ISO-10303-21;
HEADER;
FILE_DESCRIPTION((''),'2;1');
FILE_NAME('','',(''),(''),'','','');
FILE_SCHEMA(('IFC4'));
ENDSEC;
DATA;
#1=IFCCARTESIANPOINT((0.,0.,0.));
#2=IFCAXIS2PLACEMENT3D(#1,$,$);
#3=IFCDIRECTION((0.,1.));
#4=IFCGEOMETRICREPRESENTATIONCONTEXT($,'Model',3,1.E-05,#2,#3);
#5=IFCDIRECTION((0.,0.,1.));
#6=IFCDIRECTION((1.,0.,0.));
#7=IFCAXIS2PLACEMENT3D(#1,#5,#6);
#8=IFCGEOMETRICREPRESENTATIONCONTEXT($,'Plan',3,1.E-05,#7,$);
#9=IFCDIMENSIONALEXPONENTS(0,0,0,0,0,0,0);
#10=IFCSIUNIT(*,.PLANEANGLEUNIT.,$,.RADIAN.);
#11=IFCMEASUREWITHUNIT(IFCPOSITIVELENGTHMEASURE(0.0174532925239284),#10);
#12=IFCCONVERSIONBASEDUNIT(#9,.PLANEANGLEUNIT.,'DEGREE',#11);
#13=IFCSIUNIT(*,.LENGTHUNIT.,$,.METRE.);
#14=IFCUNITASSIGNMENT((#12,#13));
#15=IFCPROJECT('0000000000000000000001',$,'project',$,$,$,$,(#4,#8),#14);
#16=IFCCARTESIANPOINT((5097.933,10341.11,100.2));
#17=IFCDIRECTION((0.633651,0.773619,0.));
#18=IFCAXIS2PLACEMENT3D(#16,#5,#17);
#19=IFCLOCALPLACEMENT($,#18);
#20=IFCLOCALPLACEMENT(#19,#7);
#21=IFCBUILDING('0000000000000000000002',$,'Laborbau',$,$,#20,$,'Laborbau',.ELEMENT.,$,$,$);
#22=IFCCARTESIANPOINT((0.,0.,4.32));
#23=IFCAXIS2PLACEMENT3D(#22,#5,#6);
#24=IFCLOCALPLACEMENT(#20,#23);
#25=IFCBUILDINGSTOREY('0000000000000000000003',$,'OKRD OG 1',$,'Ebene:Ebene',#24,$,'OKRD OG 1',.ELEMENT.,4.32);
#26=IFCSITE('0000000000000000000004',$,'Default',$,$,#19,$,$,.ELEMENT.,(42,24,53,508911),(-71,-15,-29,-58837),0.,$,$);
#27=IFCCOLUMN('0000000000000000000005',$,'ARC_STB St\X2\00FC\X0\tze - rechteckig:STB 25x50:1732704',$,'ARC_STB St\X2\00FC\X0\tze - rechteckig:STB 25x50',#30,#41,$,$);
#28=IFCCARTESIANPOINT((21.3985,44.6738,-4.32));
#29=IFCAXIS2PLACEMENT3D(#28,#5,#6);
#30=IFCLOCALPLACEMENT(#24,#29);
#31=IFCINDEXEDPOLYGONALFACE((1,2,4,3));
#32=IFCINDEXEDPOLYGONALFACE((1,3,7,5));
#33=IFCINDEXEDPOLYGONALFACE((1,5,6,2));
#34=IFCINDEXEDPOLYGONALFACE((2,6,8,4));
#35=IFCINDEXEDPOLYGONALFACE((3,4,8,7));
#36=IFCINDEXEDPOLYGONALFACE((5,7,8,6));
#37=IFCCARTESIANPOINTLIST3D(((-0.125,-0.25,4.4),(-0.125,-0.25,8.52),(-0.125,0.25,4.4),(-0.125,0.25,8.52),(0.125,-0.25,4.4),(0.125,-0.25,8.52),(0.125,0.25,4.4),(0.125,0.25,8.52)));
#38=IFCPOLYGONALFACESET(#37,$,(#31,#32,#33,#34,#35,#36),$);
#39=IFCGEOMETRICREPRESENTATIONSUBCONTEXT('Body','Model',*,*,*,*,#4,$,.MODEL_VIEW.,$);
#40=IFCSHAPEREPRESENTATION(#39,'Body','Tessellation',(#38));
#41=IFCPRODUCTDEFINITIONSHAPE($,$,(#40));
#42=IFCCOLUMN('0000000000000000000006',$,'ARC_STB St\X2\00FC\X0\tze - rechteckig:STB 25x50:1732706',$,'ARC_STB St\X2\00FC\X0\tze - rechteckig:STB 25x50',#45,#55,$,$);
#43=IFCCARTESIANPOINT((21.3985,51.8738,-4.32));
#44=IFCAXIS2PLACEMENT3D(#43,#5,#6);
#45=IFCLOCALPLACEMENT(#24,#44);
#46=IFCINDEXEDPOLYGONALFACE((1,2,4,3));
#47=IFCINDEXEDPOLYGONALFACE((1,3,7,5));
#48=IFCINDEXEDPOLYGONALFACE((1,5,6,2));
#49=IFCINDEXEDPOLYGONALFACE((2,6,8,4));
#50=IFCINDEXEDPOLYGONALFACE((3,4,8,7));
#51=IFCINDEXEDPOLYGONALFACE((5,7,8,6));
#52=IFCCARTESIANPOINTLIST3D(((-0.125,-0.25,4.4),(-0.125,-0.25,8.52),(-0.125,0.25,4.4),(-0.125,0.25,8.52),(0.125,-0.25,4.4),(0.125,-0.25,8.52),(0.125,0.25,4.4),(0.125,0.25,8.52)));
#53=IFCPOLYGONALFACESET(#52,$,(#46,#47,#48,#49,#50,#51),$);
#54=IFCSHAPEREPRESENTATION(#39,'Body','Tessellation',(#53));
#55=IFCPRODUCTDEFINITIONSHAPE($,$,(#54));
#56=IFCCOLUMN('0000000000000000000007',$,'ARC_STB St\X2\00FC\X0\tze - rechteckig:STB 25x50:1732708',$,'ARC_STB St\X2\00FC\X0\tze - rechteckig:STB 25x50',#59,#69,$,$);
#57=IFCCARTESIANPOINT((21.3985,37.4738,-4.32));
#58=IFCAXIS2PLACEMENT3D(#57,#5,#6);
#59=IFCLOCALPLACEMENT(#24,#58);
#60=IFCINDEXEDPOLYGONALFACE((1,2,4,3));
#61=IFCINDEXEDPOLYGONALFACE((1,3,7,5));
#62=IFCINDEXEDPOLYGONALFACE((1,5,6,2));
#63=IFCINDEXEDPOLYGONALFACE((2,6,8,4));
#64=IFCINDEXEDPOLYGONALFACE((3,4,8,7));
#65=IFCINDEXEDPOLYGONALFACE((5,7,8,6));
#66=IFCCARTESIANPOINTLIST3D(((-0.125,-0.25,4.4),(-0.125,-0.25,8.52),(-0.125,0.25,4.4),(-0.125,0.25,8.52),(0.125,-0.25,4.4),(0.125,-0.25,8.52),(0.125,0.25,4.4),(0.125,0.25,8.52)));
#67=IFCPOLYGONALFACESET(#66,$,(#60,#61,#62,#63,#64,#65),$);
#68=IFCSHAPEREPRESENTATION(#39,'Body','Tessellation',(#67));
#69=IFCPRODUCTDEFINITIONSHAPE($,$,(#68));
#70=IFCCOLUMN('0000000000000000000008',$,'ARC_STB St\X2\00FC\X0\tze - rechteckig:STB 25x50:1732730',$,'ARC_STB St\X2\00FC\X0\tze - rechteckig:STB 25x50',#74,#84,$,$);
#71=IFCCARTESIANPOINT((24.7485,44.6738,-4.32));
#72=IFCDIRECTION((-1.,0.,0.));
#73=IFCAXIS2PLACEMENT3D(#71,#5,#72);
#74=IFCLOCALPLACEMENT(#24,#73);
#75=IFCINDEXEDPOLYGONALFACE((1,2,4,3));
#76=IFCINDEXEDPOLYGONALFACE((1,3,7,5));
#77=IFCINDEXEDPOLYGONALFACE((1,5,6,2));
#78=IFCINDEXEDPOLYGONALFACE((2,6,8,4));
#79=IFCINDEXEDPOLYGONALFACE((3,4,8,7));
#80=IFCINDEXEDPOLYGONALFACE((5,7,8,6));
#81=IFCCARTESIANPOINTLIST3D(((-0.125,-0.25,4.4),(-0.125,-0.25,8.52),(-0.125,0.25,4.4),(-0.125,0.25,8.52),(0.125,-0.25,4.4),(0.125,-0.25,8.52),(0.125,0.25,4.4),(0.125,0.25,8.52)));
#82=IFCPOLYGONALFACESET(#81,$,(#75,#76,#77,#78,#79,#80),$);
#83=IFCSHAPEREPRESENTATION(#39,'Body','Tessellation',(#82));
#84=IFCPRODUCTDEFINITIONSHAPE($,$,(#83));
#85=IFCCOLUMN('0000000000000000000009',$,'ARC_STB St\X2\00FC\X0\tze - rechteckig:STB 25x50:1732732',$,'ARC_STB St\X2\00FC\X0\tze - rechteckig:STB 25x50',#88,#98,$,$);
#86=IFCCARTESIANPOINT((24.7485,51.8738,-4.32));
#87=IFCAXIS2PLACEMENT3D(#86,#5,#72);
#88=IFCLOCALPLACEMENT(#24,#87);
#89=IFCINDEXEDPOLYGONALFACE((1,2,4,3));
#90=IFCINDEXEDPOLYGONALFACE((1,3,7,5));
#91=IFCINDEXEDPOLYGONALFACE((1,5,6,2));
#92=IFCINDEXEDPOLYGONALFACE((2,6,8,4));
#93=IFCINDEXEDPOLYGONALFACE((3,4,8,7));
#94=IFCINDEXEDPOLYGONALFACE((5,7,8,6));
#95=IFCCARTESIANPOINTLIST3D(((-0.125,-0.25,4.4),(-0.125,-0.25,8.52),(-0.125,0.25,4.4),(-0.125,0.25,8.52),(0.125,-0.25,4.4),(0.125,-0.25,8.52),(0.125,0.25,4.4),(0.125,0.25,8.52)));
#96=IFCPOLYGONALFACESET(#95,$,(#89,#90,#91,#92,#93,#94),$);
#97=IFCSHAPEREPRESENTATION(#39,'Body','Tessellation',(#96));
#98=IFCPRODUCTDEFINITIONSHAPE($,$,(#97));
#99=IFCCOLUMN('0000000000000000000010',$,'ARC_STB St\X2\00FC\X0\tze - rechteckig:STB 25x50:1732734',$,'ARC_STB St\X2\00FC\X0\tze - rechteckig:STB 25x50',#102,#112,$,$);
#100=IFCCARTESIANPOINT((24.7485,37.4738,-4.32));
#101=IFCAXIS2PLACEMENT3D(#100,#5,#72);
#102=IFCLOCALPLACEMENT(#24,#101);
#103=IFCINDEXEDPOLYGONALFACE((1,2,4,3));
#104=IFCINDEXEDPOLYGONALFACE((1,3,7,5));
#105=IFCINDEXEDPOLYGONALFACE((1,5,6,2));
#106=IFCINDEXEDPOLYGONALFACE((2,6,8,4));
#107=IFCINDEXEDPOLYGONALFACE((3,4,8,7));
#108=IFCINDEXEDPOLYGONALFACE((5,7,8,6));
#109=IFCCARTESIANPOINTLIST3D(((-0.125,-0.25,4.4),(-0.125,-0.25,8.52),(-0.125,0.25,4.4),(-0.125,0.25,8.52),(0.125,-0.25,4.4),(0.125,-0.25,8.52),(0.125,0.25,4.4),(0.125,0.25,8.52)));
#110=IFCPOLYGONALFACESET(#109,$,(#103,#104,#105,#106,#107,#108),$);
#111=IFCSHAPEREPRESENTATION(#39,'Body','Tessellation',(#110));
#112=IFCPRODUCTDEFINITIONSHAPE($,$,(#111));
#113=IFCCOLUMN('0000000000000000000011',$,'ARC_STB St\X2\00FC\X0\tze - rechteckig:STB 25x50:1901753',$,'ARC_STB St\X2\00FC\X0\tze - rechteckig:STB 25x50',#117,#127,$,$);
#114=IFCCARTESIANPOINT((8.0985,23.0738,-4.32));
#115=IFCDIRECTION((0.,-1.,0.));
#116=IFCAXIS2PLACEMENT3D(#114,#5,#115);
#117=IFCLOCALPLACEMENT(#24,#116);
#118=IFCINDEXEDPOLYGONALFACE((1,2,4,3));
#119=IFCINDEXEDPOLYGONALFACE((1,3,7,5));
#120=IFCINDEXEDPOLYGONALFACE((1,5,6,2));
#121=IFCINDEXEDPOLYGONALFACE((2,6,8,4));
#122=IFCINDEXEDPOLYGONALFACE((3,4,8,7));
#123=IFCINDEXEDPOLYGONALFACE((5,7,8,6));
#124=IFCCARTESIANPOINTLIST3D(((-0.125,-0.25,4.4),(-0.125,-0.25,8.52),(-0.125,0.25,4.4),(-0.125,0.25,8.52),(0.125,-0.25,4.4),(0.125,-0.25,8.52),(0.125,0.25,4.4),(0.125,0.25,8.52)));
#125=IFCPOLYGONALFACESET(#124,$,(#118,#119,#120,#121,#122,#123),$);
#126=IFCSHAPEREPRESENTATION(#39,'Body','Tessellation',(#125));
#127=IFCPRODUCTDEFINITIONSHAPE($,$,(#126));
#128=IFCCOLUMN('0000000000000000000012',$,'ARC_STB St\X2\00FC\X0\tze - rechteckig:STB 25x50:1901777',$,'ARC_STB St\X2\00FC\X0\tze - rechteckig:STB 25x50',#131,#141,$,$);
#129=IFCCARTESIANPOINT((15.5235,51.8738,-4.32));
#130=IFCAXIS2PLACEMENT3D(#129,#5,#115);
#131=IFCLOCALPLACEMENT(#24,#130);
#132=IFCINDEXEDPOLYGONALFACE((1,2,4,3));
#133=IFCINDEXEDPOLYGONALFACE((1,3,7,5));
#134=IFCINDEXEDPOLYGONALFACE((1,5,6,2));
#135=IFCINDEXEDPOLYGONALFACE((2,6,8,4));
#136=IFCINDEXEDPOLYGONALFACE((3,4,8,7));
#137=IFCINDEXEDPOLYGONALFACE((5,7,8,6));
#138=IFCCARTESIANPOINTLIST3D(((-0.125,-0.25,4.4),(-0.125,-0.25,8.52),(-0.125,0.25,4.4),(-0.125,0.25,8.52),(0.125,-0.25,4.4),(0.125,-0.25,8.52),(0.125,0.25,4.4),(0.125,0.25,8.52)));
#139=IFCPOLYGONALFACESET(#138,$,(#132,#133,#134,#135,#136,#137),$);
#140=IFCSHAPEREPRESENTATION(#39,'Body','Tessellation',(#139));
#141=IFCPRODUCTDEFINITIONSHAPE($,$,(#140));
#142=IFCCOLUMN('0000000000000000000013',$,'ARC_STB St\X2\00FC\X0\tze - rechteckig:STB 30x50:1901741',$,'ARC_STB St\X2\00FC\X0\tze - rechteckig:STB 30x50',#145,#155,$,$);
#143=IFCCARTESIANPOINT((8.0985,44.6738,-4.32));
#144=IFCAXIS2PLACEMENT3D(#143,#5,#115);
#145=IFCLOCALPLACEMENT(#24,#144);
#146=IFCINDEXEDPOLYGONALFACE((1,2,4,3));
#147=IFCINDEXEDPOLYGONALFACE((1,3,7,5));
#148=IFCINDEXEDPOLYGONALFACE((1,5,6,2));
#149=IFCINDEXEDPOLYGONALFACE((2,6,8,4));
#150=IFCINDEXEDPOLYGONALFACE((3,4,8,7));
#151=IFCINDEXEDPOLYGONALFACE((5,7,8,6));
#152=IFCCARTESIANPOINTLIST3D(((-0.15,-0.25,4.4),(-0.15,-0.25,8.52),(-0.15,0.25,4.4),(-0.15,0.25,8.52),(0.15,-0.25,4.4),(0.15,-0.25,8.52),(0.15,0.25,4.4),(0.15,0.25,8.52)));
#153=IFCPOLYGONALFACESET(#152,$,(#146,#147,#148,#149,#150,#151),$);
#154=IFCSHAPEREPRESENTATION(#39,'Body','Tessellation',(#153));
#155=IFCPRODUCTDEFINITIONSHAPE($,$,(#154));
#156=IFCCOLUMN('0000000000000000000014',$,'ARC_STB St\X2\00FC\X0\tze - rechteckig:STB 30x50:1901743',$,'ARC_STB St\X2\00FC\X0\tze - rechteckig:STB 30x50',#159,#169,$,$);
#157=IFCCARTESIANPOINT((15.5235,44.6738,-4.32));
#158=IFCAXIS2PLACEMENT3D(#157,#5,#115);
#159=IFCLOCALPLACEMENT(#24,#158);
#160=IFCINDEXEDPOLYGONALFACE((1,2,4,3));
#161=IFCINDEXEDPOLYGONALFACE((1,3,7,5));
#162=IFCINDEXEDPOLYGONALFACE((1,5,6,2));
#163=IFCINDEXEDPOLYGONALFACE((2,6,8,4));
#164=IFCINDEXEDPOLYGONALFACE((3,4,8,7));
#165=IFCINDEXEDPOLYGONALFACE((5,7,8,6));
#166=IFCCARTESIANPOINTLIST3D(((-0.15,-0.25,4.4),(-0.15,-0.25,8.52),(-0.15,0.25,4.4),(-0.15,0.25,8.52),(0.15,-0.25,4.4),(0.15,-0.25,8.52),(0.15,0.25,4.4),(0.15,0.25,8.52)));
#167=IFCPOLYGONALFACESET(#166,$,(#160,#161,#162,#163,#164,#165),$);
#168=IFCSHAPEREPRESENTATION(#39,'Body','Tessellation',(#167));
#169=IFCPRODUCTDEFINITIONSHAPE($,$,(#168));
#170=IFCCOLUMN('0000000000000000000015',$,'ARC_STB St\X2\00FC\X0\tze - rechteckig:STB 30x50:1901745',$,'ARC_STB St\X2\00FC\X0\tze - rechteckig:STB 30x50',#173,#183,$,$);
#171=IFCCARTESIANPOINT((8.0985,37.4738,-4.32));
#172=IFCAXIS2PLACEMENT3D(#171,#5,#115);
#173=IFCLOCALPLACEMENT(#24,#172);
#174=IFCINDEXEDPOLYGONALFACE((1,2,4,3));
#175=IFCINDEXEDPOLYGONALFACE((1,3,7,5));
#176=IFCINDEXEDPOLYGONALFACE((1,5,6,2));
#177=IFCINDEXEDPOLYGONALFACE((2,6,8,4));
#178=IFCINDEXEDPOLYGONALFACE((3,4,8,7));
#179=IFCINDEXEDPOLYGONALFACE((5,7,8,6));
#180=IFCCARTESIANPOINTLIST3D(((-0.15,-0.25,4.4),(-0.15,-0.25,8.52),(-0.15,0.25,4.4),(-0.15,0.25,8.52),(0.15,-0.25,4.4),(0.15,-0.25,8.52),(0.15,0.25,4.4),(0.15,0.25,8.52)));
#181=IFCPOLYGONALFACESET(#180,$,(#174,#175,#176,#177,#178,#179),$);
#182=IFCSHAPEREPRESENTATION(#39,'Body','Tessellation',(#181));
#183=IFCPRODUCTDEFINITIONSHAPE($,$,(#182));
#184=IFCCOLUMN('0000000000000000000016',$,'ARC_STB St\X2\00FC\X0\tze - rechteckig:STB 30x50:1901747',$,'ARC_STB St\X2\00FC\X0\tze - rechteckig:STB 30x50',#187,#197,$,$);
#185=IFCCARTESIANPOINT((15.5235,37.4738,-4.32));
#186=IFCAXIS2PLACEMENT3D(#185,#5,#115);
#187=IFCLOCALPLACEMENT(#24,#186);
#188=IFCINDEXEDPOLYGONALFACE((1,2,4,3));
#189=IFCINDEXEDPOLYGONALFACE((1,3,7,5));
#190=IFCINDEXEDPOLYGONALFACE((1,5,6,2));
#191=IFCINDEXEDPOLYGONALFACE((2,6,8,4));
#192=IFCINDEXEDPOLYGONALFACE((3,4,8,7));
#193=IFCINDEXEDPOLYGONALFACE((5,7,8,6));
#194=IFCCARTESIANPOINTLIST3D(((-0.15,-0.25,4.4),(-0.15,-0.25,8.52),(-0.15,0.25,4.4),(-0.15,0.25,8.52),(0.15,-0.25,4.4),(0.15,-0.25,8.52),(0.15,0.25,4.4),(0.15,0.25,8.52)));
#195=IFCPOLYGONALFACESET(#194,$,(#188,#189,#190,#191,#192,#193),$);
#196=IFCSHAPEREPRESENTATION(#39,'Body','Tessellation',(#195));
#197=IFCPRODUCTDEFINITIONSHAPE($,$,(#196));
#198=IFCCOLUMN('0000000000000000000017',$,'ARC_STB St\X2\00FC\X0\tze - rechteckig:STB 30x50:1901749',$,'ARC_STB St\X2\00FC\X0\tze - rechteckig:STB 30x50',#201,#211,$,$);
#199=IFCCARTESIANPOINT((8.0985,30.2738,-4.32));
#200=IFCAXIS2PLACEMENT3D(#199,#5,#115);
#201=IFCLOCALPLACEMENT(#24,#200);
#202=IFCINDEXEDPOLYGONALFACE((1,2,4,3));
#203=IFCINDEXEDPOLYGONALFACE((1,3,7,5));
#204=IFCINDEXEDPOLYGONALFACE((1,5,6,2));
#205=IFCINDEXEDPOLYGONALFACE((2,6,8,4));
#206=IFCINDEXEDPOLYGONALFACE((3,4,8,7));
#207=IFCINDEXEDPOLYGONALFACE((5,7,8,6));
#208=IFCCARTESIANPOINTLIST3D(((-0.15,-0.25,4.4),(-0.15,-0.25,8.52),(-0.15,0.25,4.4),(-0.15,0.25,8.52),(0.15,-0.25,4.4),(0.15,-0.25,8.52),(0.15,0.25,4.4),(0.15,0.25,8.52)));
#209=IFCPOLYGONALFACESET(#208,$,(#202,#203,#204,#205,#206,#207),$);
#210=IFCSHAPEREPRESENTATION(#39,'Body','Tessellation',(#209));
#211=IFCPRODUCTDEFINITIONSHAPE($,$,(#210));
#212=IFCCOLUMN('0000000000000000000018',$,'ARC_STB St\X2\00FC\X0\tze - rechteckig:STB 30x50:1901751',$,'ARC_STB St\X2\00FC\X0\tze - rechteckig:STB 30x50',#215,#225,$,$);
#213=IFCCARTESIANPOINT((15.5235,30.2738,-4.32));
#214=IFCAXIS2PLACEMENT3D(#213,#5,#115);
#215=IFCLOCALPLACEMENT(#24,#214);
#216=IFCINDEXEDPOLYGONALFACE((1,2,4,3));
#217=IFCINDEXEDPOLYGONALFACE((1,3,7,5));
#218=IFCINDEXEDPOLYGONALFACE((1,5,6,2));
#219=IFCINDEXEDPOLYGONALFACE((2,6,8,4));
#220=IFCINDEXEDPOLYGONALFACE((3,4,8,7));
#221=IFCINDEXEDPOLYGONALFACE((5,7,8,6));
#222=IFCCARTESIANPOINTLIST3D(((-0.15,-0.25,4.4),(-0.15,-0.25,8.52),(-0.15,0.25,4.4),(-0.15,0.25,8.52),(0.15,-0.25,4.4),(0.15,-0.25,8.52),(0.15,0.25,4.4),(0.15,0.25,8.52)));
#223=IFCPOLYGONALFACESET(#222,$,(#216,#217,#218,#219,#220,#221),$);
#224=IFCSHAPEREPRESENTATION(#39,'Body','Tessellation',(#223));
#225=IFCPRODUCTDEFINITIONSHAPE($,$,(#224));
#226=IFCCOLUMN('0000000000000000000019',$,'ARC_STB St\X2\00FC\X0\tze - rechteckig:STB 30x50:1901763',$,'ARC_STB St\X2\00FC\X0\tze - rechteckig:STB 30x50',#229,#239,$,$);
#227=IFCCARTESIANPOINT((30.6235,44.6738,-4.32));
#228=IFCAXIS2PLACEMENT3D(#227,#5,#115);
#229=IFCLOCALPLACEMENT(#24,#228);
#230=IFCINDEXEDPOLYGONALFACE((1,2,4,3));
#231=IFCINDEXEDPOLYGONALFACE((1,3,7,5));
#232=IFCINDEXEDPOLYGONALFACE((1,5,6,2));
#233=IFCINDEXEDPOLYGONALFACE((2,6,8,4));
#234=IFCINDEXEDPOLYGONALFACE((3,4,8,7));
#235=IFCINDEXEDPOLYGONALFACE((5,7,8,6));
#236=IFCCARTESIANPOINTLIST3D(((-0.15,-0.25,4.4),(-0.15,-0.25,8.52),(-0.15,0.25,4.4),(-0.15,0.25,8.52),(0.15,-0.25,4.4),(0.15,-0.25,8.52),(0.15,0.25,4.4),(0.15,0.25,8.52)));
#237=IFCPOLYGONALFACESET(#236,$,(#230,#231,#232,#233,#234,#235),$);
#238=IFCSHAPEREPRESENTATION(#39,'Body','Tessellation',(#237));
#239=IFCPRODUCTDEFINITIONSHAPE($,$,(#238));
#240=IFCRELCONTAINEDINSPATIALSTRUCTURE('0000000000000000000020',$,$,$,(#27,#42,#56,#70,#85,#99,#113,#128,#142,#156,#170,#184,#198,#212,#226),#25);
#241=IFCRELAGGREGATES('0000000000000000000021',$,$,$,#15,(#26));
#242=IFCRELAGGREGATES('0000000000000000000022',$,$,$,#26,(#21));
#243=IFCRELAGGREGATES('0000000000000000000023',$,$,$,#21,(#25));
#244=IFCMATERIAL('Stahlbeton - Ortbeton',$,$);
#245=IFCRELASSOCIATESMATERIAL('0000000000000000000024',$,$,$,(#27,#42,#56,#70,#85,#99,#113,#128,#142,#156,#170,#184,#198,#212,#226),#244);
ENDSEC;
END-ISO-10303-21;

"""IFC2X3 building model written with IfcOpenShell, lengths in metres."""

from ifc_helpers import new_model, entity, si_unit, converted_unit, direction, frame, origin, origin_with_axes, origin_2d_with_axis, place, context, subcontext, project, spatial, rectangle, extrude, source, transform, mapped, material, element, save


model = new_model("IFC2X3")

# Units and contexts
model_context = context("Model", 3, precision=1e-05, world=origin(), true_north=direction((0.0, 1.0)))
plan_context = context("Plan", 3, precision=1e-05, world=origin_with_axes())
body_context = subcontext(model_context, "Body", "Model", "MODEL_VIEW")
ifc_project = project(units=[converted_unit("PLANEANGLEUNIT", "DEGREE", entity("IfcPositiveLengthMeasure", 0.0174532925239284), si_unit("PLANEANGLEUNIT", "RADIAN"), dimensions=[0, 0, 0, 0, 0, 0, 0]), si_unit("LENGTHUNIT", "METRE")], contexts=[model_context, plan_context])

# Site, building, storey
site_placement = place(None, frame((5097.933, 10341.11, 100.2), z_axis=(0.0, 0.0, 1.0), x_axis=(0.633651, 0.773619, 0.0)))
site = spatial("IfcSite", under=ifc_project, at=site_placement, Name="Default", CompositionType="ELEMENT", RefLatitude=(42, 24, 53, 508911), RefLongitude=(-71, -15, -29, -58837), RefElevation=0.0)
building_placement = place(site_placement, origin_with_axes())
building = spatial("IfcBuilding", under=site, at=building_placement, Name="Laborbau", LongName="Laborbau", CompositionType="ELEMENT")
storey_placement = place(building_placement, frame((0.0, 0.0, 4.32), z_axis=(0.0, 0.0, 1.0), x_axis=(1.0, 0.0, 0.0)))
storey = spatial("IfcBuildingStorey", under=building, at=storey_placement, Name="OKRD OG 1", ObjectType="Ebene:Ebene", LongName="OKRD OG 1", CompositionType="ELEMENT", Elevation=4.32)

# Columns
ifc_material_1 = material(Name="Stahlbeton - Ortbeton")
shared_shape_1 = source(origin(), body_context, "Body", "SweptSolid", [
    extrude(rectangle(XDim=0.5, YDim=0.25, at=origin_2d_with_axis()), frame((0.0, 0.0, 4.4), z_axis=(0.0, 0.0, 1.0), x_axis=(0.0, -1.0, 0.0)), (0.0, 0.0, 1.0), 4.12),
])
for number, where, z_axis, x_axis, name in (
    (1, (21.3985, 44.6738, -4.32), (0.0, 0.0, 1.0), (1.0, 0.0, 0.0), "ARC_STB Stütze - rechteckig:STB 25x50:1732704"),
    (2, (21.3985, 51.8738, -4.32), (0.0, 0.0, 1.0), (1.0, 0.0, 0.0), "ARC_STB Stütze - rechteckig:STB 25x50:1732706"),
    (3, (21.3985, 37.4738, -4.32), (0.0, 0.0, 1.0), (1.0, 0.0, 0.0), "ARC_STB Stütze - rechteckig:STB 25x50:1732708"),
    (4, (24.7485, 44.6738, -4.32), (0.0, 0.0, 1.0), (-1.0, 0.0, 0.0), "ARC_STB Stütze - rechteckig:STB 25x50:1732730"),
    (5, (24.7485, 51.8738, -4.32), (0.0, 0.0, 1.0), (-1.0, 0.0, 0.0), "ARC_STB Stütze - rechteckig:STB 25x50:1732732"),
    (6, (24.7485, 37.4738, -4.32), (0.0, 0.0, 1.0), (-1.0, 0.0, 0.0), "ARC_STB Stütze - rechteckig:STB 25x50:1732734"),
    (7, (8.0985, 23.0738, -4.32), (0.0, 0.0, 1.0), (0.0, -1.0, 0.0), "ARC_STB Stütze - rechteckig:STB 25x50:1901753"),
    (8, (15.5235, 51.8738, -4.32), (0.0, 0.0, 1.0), (0.0, -1.0, 0.0), "ARC_STB Stütze - rechteckig:STB 25x50:1901777"),
):
    element("IfcColumn", number, at=place(storey_placement, frame(where, z_axis=z_axis, x_axis=x_axis)), inside=storey, material=ifc_material_1, Name=name, ObjectType="ARC_STB Stütze - rechteckig:STB 25x50", context=body_context, shape_type="MappedRepresentation", body=[
        mapped(shared_shape_1, transform((0.0, 0.0, 0.0), scale=1.0)),
    ])
shared_shape_2 = source(origin(), body_context, "Body", "SweptSolid", [
    extrude(rectangle(XDim=0.5, YDim=0.3, at=origin_2d_with_axis()), frame((0.0, 0.0, 4.4), z_axis=(0.0, 0.0, 1.0), x_axis=(0.0, -1.0, 0.0)), (0.0, 0.0, 1.0), 4.12),
])
for number, where, z_axis, x_axis, name in (
    (9, (8.0985, 44.6738, -4.32), (0.0, 0.0, 1.0), (0.0, -1.0, 0.0), "ARC_STB Stütze - rechteckig:STB 30x50:1901741"),
    (10, (15.5235, 44.6738, -4.32), (0.0, 0.0, 1.0), (0.0, -1.0, 0.0), "ARC_STB Stütze - rechteckig:STB 30x50:1901743"),
    (11, (8.0985, 37.4738, -4.32), (0.0, 0.0, 1.0), (0.0, -1.0, 0.0), "ARC_STB Stütze - rechteckig:STB 30x50:1901745"),
    (12, (15.5235, 37.4738, -4.32), (0.0, 0.0, 1.0), (0.0, -1.0, 0.0), "ARC_STB Stütze - rechteckig:STB 30x50:1901747"),
    (13, (8.0985, 30.2738, -4.32), (0.0, 0.0, 1.0), (0.0, -1.0, 0.0), "ARC_STB Stütze - rechteckig:STB 30x50:1901749"),
    (14, (15.5235, 30.2738, -4.32), (0.0, 0.0, 1.0), (0.0, -1.0, 0.0), "ARC_STB Stütze - rechteckig:STB 30x50:1901751"),
    (15, (30.6235, 44.6738, -4.32), (0.0, 0.0, 1.0), (0.0, -1.0, 0.0), "ARC_STB Stütze - rechteckig:STB 30x50:1901763"),
):
    element("IfcColumn", number, at=place(storey_placement, frame(where, z_axis=z_axis, x_axis=x_axis)), inside=storey, material=ifc_material_1, Name=name, ObjectType="ARC_STB Stütze - rechteckig:STB 30x50", context=body_context, shape_type="MappedRepresentation", body=[
        mapped(shared_shape_2, transform((0.0, 0.0, 0.0), scale=1.0)),
    ])

save(model, "model.ifc")
